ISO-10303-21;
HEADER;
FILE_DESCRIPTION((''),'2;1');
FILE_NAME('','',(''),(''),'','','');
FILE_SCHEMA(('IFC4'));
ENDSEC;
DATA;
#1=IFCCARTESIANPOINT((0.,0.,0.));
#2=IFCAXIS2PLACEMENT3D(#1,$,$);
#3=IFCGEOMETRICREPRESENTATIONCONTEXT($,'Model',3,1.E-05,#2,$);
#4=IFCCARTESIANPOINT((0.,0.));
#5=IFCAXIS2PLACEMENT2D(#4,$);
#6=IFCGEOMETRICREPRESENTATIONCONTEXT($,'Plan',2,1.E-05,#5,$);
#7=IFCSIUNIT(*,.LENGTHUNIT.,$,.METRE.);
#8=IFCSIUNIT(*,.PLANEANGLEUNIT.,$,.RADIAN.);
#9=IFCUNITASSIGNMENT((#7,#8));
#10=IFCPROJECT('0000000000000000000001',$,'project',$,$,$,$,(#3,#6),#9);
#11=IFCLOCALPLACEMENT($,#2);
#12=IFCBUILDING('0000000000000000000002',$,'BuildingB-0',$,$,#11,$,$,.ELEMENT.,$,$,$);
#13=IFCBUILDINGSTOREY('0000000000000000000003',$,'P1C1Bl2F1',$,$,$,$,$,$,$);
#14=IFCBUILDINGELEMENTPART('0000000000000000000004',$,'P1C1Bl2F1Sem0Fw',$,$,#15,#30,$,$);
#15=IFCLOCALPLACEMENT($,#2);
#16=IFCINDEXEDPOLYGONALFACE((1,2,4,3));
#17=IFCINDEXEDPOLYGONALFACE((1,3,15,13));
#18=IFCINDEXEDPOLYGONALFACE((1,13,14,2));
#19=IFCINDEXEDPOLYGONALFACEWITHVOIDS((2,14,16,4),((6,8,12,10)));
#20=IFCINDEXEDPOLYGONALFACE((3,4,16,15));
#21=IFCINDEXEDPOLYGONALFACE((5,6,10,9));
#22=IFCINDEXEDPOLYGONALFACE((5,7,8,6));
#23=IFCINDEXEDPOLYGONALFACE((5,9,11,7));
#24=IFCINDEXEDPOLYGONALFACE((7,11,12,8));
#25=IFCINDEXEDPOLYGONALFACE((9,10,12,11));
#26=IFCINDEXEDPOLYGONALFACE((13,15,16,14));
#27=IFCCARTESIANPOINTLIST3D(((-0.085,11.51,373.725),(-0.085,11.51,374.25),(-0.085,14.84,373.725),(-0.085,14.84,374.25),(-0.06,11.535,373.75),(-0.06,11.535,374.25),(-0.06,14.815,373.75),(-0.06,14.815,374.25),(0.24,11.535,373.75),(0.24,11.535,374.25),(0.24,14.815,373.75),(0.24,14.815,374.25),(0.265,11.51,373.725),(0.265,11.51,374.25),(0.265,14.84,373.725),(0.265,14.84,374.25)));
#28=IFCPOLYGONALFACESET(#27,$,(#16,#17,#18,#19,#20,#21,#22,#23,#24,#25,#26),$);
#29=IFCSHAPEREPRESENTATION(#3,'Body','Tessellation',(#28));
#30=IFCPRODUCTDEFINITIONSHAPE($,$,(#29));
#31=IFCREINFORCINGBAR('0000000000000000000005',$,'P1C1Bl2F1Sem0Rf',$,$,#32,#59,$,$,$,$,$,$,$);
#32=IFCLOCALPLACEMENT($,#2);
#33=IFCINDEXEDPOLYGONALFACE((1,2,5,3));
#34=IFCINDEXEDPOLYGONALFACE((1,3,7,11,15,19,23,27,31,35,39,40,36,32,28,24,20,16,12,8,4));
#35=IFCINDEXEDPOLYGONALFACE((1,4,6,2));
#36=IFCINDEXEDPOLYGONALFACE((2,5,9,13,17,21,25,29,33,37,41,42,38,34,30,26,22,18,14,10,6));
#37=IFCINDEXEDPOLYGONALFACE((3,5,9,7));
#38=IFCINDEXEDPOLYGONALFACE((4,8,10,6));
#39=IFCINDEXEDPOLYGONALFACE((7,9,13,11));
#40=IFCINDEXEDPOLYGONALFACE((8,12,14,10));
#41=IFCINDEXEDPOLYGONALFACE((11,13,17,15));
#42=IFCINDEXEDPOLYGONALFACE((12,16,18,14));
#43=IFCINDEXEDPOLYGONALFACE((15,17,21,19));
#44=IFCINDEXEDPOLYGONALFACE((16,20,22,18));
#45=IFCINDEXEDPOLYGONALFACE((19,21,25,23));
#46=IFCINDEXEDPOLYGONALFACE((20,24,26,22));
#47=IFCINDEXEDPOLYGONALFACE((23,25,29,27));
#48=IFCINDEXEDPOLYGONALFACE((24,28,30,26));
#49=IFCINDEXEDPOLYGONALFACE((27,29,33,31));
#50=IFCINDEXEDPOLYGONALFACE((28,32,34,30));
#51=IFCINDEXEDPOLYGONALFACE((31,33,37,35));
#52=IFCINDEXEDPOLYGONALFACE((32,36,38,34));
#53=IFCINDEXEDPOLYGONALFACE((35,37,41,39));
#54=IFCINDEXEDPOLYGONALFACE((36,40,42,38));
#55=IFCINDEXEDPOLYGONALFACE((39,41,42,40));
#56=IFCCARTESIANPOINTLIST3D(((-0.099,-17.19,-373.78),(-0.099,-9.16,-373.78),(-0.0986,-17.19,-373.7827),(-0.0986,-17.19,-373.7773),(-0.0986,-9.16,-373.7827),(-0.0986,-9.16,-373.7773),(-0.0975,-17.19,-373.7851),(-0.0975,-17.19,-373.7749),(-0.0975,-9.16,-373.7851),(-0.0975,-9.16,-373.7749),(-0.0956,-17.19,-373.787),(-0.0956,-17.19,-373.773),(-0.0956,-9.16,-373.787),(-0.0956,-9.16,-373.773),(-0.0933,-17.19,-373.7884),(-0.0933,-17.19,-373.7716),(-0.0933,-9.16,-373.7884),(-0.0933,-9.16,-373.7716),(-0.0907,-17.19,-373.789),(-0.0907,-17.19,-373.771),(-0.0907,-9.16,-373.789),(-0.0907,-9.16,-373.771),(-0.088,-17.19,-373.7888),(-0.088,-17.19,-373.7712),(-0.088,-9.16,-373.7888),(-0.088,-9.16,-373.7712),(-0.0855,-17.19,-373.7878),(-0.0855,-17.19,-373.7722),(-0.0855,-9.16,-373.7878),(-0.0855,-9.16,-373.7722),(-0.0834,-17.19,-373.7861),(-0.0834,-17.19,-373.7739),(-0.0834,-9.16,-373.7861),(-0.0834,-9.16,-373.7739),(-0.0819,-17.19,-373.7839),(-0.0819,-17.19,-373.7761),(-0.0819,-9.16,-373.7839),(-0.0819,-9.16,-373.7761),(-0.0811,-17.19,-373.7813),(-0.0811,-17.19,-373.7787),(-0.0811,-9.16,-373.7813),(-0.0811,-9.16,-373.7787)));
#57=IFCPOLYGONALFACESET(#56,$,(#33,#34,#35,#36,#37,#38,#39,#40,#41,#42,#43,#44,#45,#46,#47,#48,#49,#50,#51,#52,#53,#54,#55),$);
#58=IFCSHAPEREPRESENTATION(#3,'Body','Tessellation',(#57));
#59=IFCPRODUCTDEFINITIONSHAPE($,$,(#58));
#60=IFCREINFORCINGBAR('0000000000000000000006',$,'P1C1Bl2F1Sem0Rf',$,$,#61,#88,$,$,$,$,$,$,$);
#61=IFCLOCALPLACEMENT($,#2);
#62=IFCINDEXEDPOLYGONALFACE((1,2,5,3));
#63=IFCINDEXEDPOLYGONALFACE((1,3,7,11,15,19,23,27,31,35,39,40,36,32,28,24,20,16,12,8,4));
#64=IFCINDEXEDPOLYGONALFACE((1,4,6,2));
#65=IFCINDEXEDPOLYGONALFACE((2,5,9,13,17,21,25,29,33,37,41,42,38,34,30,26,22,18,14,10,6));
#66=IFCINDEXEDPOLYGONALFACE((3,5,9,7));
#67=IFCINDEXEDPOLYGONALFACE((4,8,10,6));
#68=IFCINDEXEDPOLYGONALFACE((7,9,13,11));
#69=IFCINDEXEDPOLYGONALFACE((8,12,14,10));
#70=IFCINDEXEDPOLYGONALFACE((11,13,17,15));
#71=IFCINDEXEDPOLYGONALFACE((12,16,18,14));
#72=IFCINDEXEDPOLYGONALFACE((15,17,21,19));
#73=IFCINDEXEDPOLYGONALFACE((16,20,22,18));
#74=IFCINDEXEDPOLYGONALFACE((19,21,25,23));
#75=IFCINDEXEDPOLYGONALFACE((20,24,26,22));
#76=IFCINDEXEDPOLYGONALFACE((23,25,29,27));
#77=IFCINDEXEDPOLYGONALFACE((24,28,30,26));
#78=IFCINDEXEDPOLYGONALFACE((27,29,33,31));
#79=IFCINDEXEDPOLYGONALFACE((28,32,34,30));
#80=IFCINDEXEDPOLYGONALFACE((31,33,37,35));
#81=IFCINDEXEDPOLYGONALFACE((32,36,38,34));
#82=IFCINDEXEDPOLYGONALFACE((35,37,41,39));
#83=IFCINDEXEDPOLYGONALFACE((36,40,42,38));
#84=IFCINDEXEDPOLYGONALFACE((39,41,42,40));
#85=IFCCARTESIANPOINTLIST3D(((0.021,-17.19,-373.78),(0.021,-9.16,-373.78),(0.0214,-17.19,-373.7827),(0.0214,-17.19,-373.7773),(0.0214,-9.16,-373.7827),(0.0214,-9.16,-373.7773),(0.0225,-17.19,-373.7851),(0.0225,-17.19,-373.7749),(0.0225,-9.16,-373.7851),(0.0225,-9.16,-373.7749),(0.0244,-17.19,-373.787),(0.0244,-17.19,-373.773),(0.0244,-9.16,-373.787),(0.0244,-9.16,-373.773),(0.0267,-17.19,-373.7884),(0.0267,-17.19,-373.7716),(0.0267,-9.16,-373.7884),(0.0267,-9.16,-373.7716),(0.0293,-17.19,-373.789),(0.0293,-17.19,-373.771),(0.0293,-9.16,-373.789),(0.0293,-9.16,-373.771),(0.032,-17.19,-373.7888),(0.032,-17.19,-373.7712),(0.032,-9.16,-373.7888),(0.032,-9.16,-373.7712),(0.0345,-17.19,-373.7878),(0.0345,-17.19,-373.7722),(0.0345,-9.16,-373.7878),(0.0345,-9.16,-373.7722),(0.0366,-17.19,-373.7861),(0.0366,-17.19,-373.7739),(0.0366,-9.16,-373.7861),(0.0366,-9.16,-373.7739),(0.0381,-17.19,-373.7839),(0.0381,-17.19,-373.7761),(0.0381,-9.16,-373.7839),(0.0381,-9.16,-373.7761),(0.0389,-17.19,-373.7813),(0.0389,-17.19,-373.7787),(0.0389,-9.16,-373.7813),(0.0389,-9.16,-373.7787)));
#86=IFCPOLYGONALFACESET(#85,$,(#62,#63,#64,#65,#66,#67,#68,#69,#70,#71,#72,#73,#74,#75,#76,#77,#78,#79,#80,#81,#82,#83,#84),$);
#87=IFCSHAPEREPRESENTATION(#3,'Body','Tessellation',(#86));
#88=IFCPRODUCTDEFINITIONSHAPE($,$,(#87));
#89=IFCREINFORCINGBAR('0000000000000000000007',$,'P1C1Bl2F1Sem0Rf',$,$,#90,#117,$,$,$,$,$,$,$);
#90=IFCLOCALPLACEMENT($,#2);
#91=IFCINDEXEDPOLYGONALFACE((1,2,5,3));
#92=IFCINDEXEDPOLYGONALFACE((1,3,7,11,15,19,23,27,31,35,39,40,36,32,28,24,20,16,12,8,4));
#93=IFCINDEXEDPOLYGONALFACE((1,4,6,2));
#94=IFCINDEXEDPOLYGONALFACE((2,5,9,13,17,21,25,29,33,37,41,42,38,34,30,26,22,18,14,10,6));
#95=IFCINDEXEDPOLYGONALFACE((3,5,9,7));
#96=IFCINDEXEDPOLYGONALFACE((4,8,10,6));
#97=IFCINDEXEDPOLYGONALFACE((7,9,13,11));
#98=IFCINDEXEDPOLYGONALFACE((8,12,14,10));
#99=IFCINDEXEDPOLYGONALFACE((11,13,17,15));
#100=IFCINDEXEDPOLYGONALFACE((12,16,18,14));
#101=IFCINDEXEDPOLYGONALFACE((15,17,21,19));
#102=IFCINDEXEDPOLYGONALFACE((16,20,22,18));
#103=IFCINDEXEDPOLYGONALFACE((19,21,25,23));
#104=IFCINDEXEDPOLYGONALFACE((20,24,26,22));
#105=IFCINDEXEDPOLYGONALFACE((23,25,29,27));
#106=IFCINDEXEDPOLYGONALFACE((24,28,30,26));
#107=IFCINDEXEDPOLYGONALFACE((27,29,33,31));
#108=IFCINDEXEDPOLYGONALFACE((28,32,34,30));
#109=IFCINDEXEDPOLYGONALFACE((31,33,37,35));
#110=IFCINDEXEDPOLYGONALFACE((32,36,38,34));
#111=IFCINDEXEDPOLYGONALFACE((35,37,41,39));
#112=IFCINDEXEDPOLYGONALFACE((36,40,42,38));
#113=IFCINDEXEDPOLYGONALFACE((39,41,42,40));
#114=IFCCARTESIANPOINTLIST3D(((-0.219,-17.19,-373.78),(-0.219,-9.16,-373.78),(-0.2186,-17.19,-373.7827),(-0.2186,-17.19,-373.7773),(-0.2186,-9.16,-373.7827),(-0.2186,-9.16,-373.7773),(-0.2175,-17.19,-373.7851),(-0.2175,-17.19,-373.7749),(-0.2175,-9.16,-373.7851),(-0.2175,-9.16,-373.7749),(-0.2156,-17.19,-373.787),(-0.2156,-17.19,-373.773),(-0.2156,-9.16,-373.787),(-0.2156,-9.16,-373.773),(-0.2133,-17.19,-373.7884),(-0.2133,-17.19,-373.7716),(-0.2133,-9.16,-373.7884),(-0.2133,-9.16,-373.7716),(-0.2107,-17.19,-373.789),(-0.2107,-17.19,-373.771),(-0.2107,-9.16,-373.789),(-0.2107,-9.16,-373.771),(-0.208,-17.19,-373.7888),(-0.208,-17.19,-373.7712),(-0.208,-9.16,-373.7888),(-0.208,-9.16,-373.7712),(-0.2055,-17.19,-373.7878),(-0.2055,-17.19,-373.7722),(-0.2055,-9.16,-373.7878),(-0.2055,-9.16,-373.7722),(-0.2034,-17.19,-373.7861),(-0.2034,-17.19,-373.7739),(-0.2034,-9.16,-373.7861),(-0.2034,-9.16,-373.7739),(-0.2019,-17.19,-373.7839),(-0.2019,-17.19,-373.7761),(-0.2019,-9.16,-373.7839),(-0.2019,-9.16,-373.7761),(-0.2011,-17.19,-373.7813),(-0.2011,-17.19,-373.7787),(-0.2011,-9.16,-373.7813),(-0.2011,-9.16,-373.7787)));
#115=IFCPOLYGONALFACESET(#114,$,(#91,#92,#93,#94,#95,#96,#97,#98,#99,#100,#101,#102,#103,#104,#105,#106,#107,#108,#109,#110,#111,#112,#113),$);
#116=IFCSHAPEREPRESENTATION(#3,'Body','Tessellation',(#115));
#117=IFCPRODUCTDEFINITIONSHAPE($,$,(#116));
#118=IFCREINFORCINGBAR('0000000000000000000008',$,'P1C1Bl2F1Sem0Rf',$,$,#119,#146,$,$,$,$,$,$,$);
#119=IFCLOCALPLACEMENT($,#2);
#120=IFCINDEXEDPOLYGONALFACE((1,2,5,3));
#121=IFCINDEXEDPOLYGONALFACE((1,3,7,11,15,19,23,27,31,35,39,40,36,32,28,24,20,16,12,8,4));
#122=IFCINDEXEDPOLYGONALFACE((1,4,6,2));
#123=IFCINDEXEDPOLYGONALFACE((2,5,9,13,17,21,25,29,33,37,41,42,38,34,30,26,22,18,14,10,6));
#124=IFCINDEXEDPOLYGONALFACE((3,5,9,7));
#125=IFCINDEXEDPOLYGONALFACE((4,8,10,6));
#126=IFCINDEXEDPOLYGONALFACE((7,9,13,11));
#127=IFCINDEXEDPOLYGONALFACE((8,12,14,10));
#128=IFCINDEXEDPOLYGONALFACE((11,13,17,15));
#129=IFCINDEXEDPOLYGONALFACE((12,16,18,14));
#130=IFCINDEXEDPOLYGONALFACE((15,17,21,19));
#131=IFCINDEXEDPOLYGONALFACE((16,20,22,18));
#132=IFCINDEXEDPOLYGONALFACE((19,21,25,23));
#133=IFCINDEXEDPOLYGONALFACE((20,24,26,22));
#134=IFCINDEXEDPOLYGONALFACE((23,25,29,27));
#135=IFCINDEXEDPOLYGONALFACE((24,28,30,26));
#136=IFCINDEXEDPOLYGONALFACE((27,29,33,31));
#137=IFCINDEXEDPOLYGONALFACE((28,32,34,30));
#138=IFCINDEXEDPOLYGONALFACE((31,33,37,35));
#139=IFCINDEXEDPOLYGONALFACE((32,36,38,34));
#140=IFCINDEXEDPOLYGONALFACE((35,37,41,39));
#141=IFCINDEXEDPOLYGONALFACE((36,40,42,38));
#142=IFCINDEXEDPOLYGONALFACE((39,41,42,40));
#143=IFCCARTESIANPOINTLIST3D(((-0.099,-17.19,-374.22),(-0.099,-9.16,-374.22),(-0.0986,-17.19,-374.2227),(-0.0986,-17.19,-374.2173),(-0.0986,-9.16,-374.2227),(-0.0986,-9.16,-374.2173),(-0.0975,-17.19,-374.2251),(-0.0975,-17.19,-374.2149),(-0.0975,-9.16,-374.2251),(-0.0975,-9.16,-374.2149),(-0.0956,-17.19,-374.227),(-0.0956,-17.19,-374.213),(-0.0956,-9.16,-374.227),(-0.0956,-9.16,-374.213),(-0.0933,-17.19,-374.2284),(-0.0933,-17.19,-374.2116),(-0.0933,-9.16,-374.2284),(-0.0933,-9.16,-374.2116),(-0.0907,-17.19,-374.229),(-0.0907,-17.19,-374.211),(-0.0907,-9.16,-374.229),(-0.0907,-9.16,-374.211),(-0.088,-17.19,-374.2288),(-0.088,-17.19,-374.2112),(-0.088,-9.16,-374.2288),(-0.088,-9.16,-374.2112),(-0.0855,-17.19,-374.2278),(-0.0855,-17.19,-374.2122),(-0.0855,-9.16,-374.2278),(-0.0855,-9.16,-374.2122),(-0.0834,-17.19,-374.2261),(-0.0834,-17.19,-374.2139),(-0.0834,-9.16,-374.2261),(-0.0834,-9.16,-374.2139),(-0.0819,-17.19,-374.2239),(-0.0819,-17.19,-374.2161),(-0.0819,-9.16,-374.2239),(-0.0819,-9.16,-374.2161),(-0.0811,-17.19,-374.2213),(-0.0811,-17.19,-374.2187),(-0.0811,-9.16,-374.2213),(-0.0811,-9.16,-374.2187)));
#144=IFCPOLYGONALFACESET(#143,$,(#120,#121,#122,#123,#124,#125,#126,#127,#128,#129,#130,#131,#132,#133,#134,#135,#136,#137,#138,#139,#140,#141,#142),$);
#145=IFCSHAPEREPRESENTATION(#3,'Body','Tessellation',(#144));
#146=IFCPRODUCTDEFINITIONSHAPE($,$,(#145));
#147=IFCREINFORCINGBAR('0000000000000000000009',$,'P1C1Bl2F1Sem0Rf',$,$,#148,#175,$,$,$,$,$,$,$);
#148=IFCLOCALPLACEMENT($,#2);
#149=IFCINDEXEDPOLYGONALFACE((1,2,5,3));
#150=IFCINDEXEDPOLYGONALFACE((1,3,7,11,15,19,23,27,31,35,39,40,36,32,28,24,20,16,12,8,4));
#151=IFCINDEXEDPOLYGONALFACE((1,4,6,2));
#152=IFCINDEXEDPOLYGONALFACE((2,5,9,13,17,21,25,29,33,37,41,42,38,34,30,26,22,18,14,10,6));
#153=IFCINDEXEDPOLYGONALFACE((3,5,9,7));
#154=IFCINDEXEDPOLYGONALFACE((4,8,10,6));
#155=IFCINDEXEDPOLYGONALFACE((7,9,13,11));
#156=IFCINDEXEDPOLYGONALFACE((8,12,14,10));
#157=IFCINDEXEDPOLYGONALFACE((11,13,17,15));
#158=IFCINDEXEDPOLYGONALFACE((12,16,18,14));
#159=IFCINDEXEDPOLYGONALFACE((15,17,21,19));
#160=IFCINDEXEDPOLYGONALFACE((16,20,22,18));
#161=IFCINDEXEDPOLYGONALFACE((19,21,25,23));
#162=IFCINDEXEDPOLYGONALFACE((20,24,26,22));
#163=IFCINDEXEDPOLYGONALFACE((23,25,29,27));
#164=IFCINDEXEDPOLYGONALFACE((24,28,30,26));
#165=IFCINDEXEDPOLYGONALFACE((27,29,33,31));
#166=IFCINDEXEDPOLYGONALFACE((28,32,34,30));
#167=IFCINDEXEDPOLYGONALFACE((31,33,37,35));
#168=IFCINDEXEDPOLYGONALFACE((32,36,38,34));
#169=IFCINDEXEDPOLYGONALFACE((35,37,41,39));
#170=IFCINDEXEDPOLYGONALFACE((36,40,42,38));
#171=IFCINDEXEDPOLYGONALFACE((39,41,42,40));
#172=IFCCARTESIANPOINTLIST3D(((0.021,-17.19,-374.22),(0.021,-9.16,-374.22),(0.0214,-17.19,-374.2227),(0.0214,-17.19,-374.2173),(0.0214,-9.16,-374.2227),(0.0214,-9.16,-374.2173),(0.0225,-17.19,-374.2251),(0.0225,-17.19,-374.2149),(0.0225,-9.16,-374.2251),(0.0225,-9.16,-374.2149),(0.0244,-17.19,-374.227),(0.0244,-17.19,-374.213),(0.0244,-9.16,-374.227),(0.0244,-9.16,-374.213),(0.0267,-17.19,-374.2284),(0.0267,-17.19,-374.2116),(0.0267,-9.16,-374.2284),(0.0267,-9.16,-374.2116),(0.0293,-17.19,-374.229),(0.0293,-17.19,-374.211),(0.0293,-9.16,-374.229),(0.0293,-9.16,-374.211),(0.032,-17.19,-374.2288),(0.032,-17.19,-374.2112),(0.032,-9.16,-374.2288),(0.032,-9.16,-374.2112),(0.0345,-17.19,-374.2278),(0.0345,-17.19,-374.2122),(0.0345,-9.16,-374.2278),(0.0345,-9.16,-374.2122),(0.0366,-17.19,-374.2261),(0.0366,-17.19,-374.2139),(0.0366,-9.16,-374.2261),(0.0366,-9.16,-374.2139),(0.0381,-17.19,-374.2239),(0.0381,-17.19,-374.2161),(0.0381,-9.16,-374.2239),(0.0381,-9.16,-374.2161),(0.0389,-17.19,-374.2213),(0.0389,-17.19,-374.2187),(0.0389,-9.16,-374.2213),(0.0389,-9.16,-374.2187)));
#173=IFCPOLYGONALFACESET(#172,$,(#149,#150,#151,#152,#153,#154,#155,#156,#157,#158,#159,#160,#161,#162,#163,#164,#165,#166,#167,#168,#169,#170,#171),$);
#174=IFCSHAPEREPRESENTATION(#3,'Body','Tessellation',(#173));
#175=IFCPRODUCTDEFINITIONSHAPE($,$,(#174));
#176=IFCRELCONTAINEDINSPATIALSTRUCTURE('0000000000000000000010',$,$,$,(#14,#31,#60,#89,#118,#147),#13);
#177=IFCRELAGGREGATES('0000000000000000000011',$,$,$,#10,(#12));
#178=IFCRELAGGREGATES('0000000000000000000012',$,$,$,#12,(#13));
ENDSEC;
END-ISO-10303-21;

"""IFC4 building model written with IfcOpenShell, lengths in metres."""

from ifc_helpers import new_model, entity, si_unit, origin, origin_2d, place, context, project, spatial, polyline, outline, extrude, element, save


model = new_model("IFC4")

# Units and contexts
model_context = context("Model", 3, precision=1e-05, world=origin())
plan_context = context("Plan", 2, precision=1e-05, world=origin_2d())
ifc_project = project(units=[si_unit("LENGTHUNIT", "METRE"), si_unit("PLANEANGLEUNIT", "RADIAN")], contexts=[model_context, plan_context])

# Building, storey
building_placement = place(None, origin())
building = spatial("IfcBuilding", under=ifc_project, at=building_placement, Name="BuildingB-0", CompositionType="ELEMENT")
storey = spatial("IfcBuildingStorey", under=building, Name="P1C1Bl2F1")

# Building element part, opening
building_element_part_1 = element("IfcBuildingElementPart", 1, inside=storey, Name="P1C1Bl2F1Sem0Fw", context=model_context, shape_type="SweptSolid", body=[
    extrude(outline(polyline([(-0.085, 11.51, 373.725), (-0.085, 14.84, 373.725), (0.265, 14.84, 373.725), (0.265, 11.51, 373.725), (-0.085, 11.51, 373.725)])), None, (0.0, 0.0, 1.0), 0.525),
])
element("IfcOpeningElement", 2, inside=storey, cuts=building_element_part_1, context=model_context, shape_type="SweptSolid", body=[
    extrude(outline(polyline([(-0.06, 11.535, 373.75), (-0.06, 14.815, 373.75), (0.24, 14.815, 373.75), (0.24, 11.535, 373.75), (-0.06, 11.535, 373.75)])), None, (0.0, 0.0, 1.0), 0.5),
])

# Reinforcing bars
element("IfcReinforcingBar", 3, inside=storey, Name="P1C1Bl2F1Sem0Rf", context=model_context, shape_type="SweptSolid", body=[
    entity("IfcSurfaceCurveSweptAreaSolid", entity("IfcCircleProfileDef", "AREA", None, None, 0.009), None, entity("IfcPolyline", [entity("IfcCartesianPoint", [0.09, 17.19, 373.78]), entity("IfcCartesianPoint", [0.09, 9.16, 373.78])]), None, None, entity("IfcPlane", entity("IfcAxis2Placement3D", entity("IfcCartesianPoint", [0.09, 17.19, 373.78]), entity("IfcDirection", [0.0, 0.0, 1.0]), entity("IfcDirection", [1.0, 0.0, 0.0])))),
])
element("IfcReinforcingBar", 4, inside=storey, Name="P1C1Bl2F1Sem0Rf", context=model_context, shape_type="SweptSolid", body=[
    entity("IfcSurfaceCurveSweptAreaSolid", entity("IfcCircleProfileDef", "AREA", None, None, 0.009), None, entity("IfcPolyline", [entity("IfcCartesianPoint", [-0.03, 17.19, 373.78]), entity("IfcCartesianPoint", [-0.03, 9.16, 373.78])]), None, None, entity("IfcPlane", entity("IfcAxis2Placement3D", entity("IfcCartesianPoint", [-0.03, 17.19, 373.78]), entity("IfcDirection", [0.0, 0.0, 1.0]), entity("IfcDirection", [1.0, 0.0, 0.0])))),
])
element("IfcReinforcingBar", 5, inside=storey, Name="P1C1Bl2F1Sem0Rf", context=model_context, shape_type="SweptSolid", body=[
    entity("IfcSurfaceCurveSweptAreaSolid", entity("IfcCircleProfileDef", "AREA", None, None, 0.009), None, entity("IfcPolyline", [entity("IfcCartesianPoint", [0.21, 17.19, 373.78]), entity("IfcCartesianPoint", [0.21, 9.16, 373.78])]), None, None, entity("IfcPlane", entity("IfcAxis2Placement3D", entity("IfcCartesianPoint", [0.21, 17.19, 373.78]), entity("IfcDirection", [0.0, 0.0, 1.0]), entity("IfcDirection", [1.0, 0.0, 0.0])))),
])
element("IfcReinforcingBar", 6, inside=storey, Name="P1C1Bl2F1Sem0Rf", context=model_context, shape_type="SweptSolid", body=[
    entity("IfcSurfaceCurveSweptAreaSolid", entity("IfcCircleProfileDef", "AREA", None, None, 0.009), None, entity("IfcPolyline", [entity("IfcCartesianPoint", [0.09, 17.19, 374.22]), entity("IfcCartesianPoint", [0.09, 9.16, 374.22])]), None, None, entity("IfcPlane", entity("IfcAxis2Placement3D", entity("IfcCartesianPoint", [0.09, 17.19, 374.22]), entity("IfcDirection", [0.0, 0.0, 1.0]), entity("IfcDirection", [1.0, 0.0, 0.0])))),
])
element("IfcReinforcingBar", 7, inside=storey, Name="P1C1Bl2F1Sem0Rf", context=model_context, shape_type="SweptSolid", body=[
    entity("IfcSurfaceCurveSweptAreaSolid", entity("IfcCircleProfileDef", "AREA", None, None, 0.009), None, entity("IfcPolyline", [entity("IfcCartesianPoint", [-0.03, 17.19, 374.22]), entity("IfcCartesianPoint", [-0.03, 9.16, 374.22])]), None, None, entity("IfcPlane", entity("IfcAxis2Placement3D", entity("IfcCartesianPoint", [-0.03, 17.19, 374.22]), entity("IfcDirection", [0.0, 0.0, 1.0]), entity("IfcDirection", [1.0, 0.0, 0.0])))),
])

save(model, "model.ifc")
